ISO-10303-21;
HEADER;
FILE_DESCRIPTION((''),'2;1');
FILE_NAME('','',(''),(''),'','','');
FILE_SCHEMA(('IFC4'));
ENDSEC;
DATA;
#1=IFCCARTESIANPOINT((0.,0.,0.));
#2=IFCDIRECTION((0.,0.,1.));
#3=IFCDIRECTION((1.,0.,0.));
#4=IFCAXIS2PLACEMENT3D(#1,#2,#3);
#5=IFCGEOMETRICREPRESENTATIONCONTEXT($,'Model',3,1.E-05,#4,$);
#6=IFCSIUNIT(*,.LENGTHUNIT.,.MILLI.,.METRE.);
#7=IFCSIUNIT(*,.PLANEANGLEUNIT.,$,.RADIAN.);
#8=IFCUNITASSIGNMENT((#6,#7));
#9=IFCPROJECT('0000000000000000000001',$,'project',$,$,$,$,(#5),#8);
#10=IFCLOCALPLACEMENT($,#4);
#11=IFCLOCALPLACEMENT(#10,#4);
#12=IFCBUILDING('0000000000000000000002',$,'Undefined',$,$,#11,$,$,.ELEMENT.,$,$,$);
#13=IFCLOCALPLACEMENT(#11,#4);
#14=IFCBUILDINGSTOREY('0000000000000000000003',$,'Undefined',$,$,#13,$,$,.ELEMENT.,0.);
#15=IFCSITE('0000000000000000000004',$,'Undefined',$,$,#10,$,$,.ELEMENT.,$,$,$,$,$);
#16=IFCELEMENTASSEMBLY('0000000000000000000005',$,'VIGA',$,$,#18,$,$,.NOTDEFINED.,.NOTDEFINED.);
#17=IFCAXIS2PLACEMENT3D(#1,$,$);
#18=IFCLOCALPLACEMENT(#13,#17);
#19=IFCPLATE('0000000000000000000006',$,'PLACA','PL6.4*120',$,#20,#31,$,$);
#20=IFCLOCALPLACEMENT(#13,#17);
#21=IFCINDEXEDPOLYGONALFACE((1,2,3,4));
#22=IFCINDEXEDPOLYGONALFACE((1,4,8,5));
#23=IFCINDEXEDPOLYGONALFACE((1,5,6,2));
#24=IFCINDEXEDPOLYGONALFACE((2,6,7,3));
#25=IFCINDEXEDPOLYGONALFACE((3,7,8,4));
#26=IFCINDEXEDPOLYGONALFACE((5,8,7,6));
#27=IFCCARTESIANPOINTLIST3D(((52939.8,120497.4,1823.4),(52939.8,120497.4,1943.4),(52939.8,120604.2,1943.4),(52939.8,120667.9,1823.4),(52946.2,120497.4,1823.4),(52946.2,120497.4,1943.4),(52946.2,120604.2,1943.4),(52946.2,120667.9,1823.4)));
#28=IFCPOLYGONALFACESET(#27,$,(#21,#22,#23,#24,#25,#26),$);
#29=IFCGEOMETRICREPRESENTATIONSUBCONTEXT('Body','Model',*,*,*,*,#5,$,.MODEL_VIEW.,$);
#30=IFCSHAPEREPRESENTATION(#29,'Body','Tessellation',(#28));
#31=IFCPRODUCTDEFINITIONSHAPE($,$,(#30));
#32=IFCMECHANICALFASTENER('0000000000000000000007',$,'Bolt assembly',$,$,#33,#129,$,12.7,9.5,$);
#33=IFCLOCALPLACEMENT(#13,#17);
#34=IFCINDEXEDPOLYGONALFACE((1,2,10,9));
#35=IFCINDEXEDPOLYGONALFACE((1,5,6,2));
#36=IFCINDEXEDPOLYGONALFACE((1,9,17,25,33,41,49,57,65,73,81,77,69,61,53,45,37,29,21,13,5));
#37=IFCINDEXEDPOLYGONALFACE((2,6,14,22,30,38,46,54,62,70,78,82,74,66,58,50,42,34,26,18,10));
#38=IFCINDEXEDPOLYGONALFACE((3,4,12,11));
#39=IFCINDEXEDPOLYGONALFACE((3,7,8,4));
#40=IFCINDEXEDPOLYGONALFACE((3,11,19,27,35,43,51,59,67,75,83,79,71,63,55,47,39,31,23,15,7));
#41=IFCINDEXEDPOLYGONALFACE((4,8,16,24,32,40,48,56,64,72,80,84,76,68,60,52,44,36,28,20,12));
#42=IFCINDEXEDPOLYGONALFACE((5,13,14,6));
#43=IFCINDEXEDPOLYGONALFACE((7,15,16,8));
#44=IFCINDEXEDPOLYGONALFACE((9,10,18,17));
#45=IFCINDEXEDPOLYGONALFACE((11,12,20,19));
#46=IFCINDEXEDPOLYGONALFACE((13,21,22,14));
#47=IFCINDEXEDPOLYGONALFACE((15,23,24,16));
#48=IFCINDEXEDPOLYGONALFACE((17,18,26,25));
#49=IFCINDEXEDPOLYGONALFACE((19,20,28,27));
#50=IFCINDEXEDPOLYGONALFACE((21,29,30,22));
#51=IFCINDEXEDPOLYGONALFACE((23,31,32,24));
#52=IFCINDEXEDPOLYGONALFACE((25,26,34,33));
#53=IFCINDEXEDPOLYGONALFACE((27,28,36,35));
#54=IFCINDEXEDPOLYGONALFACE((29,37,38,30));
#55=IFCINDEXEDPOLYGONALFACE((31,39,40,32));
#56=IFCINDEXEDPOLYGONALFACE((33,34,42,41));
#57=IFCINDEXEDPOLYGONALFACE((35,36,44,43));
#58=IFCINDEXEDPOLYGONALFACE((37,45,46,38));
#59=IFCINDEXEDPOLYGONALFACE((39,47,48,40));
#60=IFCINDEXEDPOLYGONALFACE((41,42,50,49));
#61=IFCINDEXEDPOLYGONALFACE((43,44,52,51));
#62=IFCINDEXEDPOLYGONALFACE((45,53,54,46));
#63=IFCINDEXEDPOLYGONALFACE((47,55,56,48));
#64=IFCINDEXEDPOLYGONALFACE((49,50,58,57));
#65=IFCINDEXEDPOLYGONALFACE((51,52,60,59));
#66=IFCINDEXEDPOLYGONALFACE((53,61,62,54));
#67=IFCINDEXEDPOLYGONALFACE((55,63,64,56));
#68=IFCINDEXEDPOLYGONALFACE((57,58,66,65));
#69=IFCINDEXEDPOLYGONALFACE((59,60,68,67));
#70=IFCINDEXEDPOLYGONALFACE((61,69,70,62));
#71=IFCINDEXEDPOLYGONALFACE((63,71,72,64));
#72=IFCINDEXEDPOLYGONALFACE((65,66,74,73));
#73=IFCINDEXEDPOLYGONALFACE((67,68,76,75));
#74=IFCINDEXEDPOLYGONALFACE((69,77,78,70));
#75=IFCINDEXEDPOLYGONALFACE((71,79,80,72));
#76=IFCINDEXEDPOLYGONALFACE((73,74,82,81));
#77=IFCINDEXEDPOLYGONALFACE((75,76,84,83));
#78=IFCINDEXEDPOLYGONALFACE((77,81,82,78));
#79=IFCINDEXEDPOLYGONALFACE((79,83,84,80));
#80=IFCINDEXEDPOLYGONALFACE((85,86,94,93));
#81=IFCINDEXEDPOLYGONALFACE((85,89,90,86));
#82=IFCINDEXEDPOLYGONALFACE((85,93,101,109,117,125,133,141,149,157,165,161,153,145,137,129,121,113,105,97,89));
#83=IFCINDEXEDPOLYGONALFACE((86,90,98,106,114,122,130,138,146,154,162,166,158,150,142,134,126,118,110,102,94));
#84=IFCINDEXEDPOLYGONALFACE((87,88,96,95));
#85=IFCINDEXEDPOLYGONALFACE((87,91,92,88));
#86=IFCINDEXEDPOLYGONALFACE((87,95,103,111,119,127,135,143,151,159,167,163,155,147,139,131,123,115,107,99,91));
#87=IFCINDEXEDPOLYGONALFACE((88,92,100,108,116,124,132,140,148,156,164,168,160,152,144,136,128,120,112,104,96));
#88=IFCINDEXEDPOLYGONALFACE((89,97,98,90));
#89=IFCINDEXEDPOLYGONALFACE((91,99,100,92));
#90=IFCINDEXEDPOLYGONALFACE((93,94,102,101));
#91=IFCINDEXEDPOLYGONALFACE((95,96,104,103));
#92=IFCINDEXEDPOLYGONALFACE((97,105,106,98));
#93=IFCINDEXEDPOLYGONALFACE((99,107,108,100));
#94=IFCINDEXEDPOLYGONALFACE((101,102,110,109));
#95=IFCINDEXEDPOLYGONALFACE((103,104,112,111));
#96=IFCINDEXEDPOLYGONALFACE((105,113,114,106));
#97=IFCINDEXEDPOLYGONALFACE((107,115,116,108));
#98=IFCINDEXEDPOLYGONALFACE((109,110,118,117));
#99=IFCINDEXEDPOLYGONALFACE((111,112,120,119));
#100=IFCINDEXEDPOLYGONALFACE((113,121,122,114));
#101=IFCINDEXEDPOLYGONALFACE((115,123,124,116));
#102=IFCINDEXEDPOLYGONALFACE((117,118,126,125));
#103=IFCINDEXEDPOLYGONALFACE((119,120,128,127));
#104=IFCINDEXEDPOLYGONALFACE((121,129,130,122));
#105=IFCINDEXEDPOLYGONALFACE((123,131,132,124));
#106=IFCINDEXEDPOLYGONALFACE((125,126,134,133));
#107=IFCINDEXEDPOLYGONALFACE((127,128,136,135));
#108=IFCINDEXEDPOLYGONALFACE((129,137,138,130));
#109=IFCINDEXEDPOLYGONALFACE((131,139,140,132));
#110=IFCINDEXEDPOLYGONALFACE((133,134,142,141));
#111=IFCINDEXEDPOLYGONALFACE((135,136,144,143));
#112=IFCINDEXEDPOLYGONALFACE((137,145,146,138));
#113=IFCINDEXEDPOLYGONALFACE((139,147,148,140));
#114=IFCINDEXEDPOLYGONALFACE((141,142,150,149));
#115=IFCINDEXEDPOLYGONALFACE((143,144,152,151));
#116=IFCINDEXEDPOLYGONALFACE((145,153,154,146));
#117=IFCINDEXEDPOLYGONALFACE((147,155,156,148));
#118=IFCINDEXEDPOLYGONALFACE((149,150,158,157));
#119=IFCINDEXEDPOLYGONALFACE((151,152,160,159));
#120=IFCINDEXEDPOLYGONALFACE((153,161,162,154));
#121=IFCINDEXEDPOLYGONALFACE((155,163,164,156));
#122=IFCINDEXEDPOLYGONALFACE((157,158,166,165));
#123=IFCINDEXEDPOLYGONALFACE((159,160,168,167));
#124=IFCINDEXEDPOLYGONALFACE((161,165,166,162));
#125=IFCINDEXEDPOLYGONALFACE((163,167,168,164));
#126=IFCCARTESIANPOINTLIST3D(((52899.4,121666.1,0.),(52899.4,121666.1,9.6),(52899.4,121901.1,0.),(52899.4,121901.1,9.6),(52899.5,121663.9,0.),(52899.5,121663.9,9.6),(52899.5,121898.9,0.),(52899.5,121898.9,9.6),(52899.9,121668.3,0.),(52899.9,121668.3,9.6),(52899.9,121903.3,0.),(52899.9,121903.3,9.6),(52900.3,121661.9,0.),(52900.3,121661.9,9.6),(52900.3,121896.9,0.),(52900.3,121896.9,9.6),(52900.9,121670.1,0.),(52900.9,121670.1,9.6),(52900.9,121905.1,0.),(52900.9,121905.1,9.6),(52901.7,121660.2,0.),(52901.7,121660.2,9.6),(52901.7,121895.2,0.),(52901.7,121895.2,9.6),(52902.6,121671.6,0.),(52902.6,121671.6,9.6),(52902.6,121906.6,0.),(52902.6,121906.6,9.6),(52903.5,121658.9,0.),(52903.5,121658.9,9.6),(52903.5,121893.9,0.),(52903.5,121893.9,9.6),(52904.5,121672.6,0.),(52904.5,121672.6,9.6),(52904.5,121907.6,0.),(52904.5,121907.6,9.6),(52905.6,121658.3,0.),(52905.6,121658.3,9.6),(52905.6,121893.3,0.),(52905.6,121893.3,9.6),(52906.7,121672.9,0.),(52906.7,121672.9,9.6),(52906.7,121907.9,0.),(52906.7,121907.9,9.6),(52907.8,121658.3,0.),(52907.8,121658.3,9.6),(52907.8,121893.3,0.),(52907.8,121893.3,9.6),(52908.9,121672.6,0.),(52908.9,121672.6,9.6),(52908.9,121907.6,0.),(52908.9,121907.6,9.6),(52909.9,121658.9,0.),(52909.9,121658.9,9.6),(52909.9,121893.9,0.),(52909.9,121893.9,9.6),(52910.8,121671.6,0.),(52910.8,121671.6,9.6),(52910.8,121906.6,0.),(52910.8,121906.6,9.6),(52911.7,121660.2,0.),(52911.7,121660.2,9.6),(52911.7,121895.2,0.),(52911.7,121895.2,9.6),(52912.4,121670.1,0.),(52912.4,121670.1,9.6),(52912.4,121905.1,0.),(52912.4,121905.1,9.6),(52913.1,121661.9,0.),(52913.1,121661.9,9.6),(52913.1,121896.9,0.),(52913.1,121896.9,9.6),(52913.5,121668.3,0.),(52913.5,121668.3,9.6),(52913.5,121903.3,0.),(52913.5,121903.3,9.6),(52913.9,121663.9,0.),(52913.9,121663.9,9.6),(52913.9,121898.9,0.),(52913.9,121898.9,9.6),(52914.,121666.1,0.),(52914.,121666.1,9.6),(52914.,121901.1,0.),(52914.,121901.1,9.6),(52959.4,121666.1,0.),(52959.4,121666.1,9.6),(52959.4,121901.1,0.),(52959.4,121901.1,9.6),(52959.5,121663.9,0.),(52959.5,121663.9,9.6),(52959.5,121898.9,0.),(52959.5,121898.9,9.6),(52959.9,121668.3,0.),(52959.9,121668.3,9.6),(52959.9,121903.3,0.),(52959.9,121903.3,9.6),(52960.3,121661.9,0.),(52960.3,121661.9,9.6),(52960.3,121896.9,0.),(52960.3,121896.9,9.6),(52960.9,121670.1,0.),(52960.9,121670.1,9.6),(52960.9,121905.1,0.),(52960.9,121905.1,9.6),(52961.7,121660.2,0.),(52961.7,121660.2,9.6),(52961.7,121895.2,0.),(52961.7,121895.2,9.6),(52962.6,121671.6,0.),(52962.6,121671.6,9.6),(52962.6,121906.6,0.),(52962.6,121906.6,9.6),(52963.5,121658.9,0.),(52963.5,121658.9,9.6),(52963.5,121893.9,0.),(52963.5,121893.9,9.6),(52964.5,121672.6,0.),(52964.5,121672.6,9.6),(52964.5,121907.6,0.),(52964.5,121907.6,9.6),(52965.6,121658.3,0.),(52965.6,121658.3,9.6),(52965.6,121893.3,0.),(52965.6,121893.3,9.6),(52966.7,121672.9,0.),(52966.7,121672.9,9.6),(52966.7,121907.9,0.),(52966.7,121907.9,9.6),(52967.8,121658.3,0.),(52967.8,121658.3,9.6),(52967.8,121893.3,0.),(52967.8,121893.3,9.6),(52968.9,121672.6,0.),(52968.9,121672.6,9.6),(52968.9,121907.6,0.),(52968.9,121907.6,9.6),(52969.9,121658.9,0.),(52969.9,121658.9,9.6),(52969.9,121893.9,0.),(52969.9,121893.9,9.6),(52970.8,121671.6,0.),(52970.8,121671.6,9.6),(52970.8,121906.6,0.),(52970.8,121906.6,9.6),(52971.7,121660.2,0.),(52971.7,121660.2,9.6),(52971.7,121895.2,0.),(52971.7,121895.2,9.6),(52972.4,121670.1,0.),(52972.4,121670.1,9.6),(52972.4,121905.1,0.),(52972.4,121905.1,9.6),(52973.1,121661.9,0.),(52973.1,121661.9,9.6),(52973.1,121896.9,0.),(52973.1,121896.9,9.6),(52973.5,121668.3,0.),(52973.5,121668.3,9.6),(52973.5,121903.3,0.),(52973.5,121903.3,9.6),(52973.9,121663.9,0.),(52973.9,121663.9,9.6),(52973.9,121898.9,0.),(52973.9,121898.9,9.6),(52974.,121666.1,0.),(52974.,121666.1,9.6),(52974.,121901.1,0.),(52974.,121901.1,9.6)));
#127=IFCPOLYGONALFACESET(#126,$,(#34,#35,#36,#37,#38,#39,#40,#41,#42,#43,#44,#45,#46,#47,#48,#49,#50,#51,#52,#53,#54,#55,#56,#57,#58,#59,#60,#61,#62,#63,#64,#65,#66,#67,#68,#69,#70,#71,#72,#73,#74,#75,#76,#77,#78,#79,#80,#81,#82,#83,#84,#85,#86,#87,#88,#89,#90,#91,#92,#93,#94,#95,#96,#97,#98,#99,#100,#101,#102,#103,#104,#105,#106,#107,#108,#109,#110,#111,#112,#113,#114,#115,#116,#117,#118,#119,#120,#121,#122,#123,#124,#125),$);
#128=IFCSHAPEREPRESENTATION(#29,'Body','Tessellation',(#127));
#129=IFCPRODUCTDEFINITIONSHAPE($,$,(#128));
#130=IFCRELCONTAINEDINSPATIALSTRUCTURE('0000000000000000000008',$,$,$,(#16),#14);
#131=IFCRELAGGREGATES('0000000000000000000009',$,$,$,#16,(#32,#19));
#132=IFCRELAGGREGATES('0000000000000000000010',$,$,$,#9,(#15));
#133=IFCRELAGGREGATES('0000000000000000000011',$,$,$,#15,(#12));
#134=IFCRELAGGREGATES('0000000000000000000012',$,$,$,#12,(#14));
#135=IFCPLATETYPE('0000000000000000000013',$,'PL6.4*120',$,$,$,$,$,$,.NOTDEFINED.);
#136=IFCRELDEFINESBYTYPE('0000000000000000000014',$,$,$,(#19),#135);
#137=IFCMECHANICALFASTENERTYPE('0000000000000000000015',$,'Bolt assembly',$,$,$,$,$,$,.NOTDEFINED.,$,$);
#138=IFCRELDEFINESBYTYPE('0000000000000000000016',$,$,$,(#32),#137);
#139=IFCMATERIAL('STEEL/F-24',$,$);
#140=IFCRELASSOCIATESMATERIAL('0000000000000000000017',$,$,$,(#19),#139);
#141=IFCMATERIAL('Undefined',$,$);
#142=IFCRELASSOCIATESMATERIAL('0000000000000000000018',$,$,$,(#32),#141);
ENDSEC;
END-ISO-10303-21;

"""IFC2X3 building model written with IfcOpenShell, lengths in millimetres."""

from ifc_helpers import new_model, si_unit, frame, origin_with_axes, origin_2d_with_axis, place, context, subcontext, project, spatial, polyline, circle, outline, extrude, source, transform, mapped, material, type_object, element, aggregate, save


model = new_model("IFC2X3")

# Units and contexts
model_context = context("Model", 3, precision=1e-05, world=origin_with_axes())
body_context = subcontext(model_context, "Body", "Model", "MODEL_VIEW")
ifc_project = project(units=[si_unit("LENGTHUNIT", "METRE", prefix="MILLI"), si_unit("PLANEANGLEUNIT", "RADIAN")], contexts=[model_context])

# Site, building, storey
site_placement = place(None, origin_with_axes())
site = spatial("IfcSite", under=ifc_project, at=site_placement, Name="Undefined", CompositionType="ELEMENT")
building_placement = place(site_placement, origin_with_axes())
building = spatial("IfcBuilding", under=site, at=building_placement, Name="Undefined", CompositionType="ELEMENT")
storey_placement = place(building_placement, origin_with_axes())
storey = spatial("IfcBuildingStorey", under=building, at=storey_placement, Name="Undefined", CompositionType="ELEMENT", Elevation=0.0)

# Element assembly
assembly_1_placement = place(storey_placement, origin_with_axes())
assembly_1 = element("IfcElementAssembly", 1, at=assembly_1_placement, inside=storey, Name="VIGA", AssemblyPlace="NOTDEFINED", PredefinedType="NOTDEFINED")
ifc_material_1 = material(Name="STEEL/F-24")

# Plate
plate_type_1 = type_object("IfcPlateType", Name="PL6.4*120", PredefinedType="NOTDEFINED")
plate_1_placement = place(assembly_1_placement, frame((52943.0, 120604.2, 1943.4), z_axis=(1.0, 0.0, 0.0), x_axis=(0.0, -1.0, 0.0)))
plate_1 = element("IfcPlate", 2, at=plate_1_placement, type_object=plate_type_1, material=ifc_material_1, Name="PLACA", Description="PL6.4*120", context=body_context, shape_type="SweptSolid", body=[
    extrude(outline(polyline([(0.0, 0.0), (106.8, 0.0), (106.8, 120.0), (-63.7, 120.0), (0.0, 0.0)])), frame((0.0, 0.0, -3.2), z_axis=(0.0, 0.0, 1.0), x_axis=(1.0, 0.0, 0.0)), (0.0, 0.0, 1.0), 6.4),
])

# Shared definitions
ifc_material_2 = material(Name="Undefined")
mechanical_fastener_type = type_object("IfcMechanicalFastenerType", Name="Bolt assembly")

# Mechanical fastener
shared_shape_1 = source(origin_with_axes(), body_context, "Body", "SweptSolid", [
    extrude(circle(Radius=7.3, at=origin_2d_with_axis()), frame((0.0, -9.5, 0.0), z_axis=(0.0, 1.0, 0.0), x_axis=(1.0, 0.0, 0.0)), (0.0, 0.0, 1.0), 9.6),
])
mechanical_fastener_1_placement = place(assembly_1_placement, frame((52936.7, 121665.6, 9.5), z_axis=(1.0, 0.0, 0.0), x_axis=(0.0, 1.0, 0.0)))
mechanical_fastener_1 = element("IfcMechanicalFastener", 3, at=mechanical_fastener_1_placement, type_object=mechanical_fastener_type, material=ifc_material_2, Name="Bolt assembly", NominalDiameter=12.7, NominalLength=9.5, context=body_context, shape_type="MappedRepresentation", body=[
    mapped(shared_shape_1, transform((0.0, 0.0, -30.0))),
    mapped(shared_shape_1, transform((235.0, 0.0, -30.0))),
    mapped(shared_shape_1, transform((0.0, 0.0, 30.0))),
    mapped(shared_shape_1, transform((235.0, 0.0, 30.0))),
])
aggregate(assembly_1, [mechanical_fastener_1, plate_1])

save(model, "model.ifc")
